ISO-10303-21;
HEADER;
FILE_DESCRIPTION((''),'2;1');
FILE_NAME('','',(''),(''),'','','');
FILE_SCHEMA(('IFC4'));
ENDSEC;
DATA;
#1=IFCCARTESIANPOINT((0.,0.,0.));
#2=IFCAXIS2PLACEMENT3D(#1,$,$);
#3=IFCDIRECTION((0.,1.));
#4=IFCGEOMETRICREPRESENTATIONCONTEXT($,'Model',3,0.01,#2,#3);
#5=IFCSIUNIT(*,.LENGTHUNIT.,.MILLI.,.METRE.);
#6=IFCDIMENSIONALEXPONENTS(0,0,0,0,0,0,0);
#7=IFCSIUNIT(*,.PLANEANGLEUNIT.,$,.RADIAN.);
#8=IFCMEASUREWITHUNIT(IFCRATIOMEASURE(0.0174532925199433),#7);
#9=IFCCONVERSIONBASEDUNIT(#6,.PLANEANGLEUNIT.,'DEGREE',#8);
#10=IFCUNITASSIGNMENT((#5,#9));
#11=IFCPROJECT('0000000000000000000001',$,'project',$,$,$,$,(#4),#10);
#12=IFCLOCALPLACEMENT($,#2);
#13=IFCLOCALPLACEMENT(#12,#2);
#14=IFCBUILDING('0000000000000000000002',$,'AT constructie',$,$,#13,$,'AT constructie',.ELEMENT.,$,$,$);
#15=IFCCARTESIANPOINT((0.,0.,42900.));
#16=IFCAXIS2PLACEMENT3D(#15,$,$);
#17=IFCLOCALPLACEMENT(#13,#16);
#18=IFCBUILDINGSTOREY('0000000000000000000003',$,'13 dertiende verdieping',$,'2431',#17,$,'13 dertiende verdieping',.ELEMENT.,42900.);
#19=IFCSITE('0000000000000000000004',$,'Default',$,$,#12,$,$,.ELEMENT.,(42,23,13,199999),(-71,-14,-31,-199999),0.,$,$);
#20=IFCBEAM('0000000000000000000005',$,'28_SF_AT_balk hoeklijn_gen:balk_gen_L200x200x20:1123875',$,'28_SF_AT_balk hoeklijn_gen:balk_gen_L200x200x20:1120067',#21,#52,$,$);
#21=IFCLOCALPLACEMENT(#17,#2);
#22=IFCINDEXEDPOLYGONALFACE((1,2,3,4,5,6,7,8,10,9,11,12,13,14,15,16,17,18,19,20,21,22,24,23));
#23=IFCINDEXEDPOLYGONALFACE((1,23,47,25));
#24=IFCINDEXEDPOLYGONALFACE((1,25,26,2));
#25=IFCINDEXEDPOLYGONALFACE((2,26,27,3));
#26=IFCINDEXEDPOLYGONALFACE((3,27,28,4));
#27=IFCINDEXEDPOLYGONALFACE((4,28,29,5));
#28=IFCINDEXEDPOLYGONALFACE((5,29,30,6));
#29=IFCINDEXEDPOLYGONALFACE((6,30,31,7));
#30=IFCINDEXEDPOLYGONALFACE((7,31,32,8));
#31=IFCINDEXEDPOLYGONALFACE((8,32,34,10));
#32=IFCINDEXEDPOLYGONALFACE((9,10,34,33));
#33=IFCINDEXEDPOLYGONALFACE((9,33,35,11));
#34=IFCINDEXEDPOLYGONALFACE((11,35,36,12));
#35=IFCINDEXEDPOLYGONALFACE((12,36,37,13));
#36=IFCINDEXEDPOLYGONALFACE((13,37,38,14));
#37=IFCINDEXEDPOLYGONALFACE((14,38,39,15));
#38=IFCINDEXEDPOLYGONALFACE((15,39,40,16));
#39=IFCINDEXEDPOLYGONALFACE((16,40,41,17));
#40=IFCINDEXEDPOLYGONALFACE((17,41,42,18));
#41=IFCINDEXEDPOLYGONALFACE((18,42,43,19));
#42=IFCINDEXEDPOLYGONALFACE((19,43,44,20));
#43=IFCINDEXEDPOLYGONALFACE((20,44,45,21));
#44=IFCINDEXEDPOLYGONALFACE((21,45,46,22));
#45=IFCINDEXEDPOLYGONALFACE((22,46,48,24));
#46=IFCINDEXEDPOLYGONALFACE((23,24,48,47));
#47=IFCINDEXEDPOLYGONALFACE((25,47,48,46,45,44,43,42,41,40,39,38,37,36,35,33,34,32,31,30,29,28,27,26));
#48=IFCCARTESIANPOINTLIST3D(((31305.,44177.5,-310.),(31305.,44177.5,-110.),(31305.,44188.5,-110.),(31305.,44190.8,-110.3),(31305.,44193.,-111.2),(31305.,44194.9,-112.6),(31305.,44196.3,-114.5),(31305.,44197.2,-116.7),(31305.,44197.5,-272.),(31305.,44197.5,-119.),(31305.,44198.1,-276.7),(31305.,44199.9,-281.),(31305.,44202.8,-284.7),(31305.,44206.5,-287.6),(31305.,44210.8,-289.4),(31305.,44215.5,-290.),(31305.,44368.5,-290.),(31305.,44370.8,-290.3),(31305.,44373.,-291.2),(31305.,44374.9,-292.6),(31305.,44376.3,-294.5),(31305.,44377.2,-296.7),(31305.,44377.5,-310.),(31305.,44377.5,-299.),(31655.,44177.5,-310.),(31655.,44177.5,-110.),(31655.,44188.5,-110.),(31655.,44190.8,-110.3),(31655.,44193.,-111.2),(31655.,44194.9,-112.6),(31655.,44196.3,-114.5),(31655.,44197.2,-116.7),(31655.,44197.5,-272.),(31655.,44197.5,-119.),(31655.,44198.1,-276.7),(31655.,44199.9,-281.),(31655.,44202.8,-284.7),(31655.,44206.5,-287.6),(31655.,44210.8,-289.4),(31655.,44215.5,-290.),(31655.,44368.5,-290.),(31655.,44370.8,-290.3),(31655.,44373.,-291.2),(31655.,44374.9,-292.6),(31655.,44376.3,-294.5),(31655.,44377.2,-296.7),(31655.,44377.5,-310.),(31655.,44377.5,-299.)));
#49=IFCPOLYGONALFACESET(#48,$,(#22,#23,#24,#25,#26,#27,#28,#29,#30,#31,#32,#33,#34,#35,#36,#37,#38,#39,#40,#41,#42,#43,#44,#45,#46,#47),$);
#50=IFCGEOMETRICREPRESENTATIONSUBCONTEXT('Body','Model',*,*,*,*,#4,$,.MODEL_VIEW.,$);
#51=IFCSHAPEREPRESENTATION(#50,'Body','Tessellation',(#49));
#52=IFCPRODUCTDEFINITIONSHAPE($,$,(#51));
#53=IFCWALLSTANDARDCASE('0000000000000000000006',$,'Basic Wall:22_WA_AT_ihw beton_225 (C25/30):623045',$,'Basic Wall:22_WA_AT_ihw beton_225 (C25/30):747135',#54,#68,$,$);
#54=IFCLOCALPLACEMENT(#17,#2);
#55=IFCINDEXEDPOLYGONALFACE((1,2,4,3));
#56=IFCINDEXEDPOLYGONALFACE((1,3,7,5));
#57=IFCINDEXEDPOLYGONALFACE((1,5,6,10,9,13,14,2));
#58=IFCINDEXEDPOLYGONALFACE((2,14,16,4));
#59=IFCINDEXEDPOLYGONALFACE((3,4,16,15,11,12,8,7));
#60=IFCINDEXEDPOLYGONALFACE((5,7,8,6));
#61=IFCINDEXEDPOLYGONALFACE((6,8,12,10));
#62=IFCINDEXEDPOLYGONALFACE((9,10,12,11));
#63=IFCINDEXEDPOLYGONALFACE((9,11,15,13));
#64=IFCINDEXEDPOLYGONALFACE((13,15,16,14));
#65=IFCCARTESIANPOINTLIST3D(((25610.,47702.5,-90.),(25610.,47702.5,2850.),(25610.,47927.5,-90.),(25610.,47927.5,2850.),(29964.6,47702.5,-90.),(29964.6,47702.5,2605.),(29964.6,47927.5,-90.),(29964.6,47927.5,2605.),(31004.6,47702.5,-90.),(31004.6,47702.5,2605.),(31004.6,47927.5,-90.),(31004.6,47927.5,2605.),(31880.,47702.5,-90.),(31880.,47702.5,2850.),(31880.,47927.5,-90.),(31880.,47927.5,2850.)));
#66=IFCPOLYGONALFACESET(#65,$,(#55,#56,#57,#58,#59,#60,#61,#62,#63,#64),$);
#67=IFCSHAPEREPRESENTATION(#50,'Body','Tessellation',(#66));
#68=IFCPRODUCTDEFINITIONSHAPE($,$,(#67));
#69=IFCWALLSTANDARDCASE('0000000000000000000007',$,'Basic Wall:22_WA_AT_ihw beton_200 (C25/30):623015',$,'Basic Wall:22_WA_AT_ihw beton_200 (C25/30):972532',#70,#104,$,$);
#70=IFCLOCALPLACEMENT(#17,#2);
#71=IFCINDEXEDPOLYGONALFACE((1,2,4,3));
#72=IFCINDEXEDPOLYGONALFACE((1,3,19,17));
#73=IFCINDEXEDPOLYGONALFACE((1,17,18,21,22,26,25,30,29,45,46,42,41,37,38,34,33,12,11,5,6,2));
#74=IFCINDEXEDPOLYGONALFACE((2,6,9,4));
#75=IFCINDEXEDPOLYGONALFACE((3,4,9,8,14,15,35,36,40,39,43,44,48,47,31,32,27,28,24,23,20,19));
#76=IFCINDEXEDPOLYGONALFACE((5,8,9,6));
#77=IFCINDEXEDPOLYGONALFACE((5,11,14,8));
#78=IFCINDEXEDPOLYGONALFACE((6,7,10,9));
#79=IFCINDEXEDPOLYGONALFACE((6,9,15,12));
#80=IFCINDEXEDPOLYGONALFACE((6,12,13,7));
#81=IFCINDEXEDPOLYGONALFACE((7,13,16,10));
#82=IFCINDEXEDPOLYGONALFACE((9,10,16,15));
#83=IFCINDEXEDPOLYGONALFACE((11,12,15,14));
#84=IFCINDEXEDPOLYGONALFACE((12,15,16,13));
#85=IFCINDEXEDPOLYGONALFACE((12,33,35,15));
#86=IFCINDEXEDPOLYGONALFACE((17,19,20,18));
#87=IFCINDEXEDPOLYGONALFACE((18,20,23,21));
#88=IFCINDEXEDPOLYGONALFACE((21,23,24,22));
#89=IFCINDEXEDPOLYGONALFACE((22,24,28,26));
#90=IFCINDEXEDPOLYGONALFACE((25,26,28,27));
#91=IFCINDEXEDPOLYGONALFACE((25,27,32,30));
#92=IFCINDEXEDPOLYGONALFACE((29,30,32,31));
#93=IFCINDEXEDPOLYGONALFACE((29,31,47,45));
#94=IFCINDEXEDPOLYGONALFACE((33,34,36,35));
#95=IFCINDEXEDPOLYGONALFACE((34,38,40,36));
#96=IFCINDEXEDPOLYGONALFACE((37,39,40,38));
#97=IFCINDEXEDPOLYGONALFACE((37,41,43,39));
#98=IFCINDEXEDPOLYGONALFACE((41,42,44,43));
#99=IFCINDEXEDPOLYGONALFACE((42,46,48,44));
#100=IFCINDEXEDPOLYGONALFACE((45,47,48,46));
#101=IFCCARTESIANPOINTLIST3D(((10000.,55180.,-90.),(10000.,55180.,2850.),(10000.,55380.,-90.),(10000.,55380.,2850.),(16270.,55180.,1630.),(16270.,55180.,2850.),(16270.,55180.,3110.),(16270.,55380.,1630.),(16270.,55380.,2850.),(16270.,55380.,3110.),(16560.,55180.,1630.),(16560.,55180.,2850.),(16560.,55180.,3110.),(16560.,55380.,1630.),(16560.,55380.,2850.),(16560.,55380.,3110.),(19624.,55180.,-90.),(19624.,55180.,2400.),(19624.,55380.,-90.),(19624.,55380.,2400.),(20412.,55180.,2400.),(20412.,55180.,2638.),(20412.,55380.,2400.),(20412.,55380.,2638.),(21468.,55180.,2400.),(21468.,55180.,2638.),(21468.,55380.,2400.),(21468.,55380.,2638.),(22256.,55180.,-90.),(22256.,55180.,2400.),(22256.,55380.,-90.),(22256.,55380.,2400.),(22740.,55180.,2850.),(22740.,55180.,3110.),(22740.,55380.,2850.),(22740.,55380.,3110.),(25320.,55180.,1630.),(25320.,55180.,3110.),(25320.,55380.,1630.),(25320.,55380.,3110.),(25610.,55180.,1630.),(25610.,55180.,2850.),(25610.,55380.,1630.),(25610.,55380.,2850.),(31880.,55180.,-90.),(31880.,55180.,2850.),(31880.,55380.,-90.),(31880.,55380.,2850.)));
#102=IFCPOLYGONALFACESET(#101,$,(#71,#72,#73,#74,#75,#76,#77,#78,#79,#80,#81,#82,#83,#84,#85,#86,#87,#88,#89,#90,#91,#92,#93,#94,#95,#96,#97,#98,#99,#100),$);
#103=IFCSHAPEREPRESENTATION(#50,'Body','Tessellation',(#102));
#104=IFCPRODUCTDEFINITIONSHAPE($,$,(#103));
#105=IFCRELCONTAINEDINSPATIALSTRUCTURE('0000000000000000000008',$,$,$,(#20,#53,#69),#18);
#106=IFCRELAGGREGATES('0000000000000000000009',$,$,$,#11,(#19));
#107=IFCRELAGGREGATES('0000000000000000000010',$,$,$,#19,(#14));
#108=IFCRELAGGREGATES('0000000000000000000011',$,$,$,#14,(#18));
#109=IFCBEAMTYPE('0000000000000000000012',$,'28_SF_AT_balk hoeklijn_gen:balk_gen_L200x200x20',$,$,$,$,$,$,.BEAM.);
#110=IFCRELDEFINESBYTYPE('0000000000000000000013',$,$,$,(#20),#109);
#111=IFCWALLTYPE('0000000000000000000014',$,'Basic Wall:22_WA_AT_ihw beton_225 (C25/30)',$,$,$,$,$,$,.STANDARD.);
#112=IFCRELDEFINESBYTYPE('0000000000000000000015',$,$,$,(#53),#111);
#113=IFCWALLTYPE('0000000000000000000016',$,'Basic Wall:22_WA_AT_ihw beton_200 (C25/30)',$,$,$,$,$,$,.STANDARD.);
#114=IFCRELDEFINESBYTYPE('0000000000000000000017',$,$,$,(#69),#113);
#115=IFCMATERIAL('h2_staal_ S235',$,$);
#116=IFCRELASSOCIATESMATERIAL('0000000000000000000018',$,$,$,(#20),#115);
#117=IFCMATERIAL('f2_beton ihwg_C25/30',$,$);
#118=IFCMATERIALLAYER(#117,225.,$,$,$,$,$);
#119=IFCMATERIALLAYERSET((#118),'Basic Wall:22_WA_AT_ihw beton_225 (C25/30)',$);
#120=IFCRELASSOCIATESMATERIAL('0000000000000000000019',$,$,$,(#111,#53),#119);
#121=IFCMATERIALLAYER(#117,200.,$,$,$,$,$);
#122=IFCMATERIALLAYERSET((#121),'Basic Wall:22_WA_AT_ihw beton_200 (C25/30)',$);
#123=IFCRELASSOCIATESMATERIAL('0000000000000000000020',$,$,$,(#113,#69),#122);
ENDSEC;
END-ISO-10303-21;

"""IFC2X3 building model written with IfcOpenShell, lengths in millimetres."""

from ifc_helpers import new_model, entity, si_unit, converted_unit, direction, frame, frame_2d, origin, place, context, subcontext, project, spatial, polyline, circle_curve, parameter, trimmed, segment, composite_curve, rectangle, outline, extrude, clip, bounded_halfspace, material, layer, layer_set, layer_usage, type_object, element, save


model = new_model("IFC2X3")

# Units and contexts
model_context = context("Model", 3, precision=0.01, world=origin(), true_north=direction((0.0, 1.0)))
body_context = subcontext(model_context, "Body", "Model", "MODEL_VIEW")
ifc_project = project(units=[si_unit("LENGTHUNIT", "METRE", prefix="MILLI"), converted_unit("PLANEANGLEUNIT", "DEGREE", entity("IfcRatioMeasure", 0.0174532925199433), si_unit("PLANEANGLEUNIT", "RADIAN"), dimensions=[0, 0, 0, 0, 0, 0, 0])], contexts=[model_context])

# Site, building, storey
site_placement = place(None, origin())
site = spatial("IfcSite", under=ifc_project, at=site_placement, Name="Default", CompositionType="ELEMENT", RefLatitude=(42, 23, 13, 199999), RefLongitude=(-71, -14, -31, -199999), RefElevation=0.0)
building_placement = place(site_placement, origin())
building = spatial("IfcBuilding", under=site, at=building_placement, Name="AT constructie", LongName="AT constructie", CompositionType="ELEMENT")
storey_placement = place(building_placement, frame((0.0, 0.0, 42900.0)))
storey = spatial("IfcBuildingStorey", under=building, at=storey_placement, Name="13 dertiende verdieping", ObjectType="2431", LongName="13 dertiende verdieping", CompositionType="ELEMENT", Elevation=42900.0)

# Beam
ifc_material_1 = material(Name="h2_staal_ S235")
beam_type = type_object("IfcBeamType", Name="28_SF_AT_balk hoeklijn_gen:balk_gen_L200x200x20", PredefinedType="BEAM")
beam_placement = place(storey_placement, frame((31305.0, 44177.5, -70.0)))
element("IfcBeam", 1, at=beam_placement, inside=storey, type_object=beam_type, material=ifc_material_1, Name="28_SF_AT_balk hoeklijn_gen:balk_gen_L200x200x20:1123875", ObjectType="28_SF_AT_balk hoeklijn_gen:balk_gen_L200x200x20:1120067", context=body_context, shape_type="SweptSolid", body=[
    extrude(outline(composite_curve([segment(polyline([(-124.4, -75.6), (75.6, -75.6)]), True, "CONTINUOUS"), segment(polyline([(75.6, -75.6), (75.6, 124.4)]), True, "CONTINUOUS"), segment(polyline([(75.6, 124.4), (64.6, 124.4)]), True, "CONTINUOUS"), segment(trimmed(circle_curve(frame_2d((64.6, 115.4), x_axis=(0.0, 1.0)), 9.0), [parameter(0.0)], [parameter(90.0)], True, "PARAMETER"), True, "CONTINUOUS"), segment(polyline([(55.6, 115.4), (55.6, -37.6)]), True, "CONTINUOUS"), segment(trimmed(circle_curve(frame_2d((37.6, -37.6), x_axis=(1.0, 0.0)), 18.0), [parameter(270.0)], [parameter(0.0)], True, "PARAMETER"), False, "CONTINUOUS"), segment(polyline([(37.6, -55.6), (-115.4, -55.6)]), True, "CONTINUOUS"), segment(trimmed(circle_curve(frame_2d((-115.4, -64.6), x_axis=(0.0, 1.0)), 9.0), [parameter(0.0)], [parameter(90.0)], True, "PARAMETER"), True, "CONTINUOUS"), segment(polyline([(-124.4, -64.6), (-124.4, -75.6)]), True, "CONTINUOUS")], self_intersect=False)), frame((0.0, 75.6, -164.4), z_axis=(1.0, 0.0, 0.0), x_axis=(0.0, 0.0, -1.0)), (0.0, 0.0, 1.0), 350.0),
])

# Wall, opening
ifc_material_2 = material(Name="f2_beton ihwg_C25/30")
ifc_layer_1 = layer(ifc_material_2, 225.0)
ifc_layer_set_1 = layer_set([ifc_layer_1], Name="Basic Wall:22_WA_AT_ihw beton_225 (C25/30)")
ifc_layer_usage_1 = layer_usage(ifc_layer_set_1, "AXIS2", "NEGATIVE", 112.5)
wall_type_1 = type_object("IfcWallType", Name="Basic Wall:22_WA_AT_ihw beton_225 (C25/30)", PredefinedType="STANDARD", material=ifc_layer_set_1)
wall_1_placement = place(storey_placement, frame((25610.0, 47815.0, -90.0)))
wall_1 = element("IfcWallStandardCase", 2, at=wall_1_placement, inside=storey, type_object=wall_type_1, material=ifc_layer_usage_1, Name="Basic Wall:22_WA_AT_ihw beton_225 (C25/30):623045", ObjectType="Basic Wall:22_WA_AT_ihw beton_225 (C25/30):747135", context=body_context, shape_type="SweptSolid", body=[
    extrude(rectangle(XDim=6270.0, YDim=225.0, at=frame_2d((3135.0, 0.0), x_axis=(-1.0, 0.0))), origin(), (0.0, 0.0, 1.0), 2940.0),
])
opening_1_placement = place(wall_1_placement, origin())
element("IfcOpeningElement", 3, at=opening_1_placement, cuts=wall_1, ObjectType="Opening", context=body_context, shape_type="SweptSolid", body=[
    extrude(rectangle(XDim=2695.0, YDim=1040.0, at=frame_2d((0.0, 0.0), x_axis=(1.0, 0.0))), frame((4874.6, -1411.5, 1347.5), z_axis=(0.0, 1.0, 0.0), x_axis=(0.0, 0.0, -1.0)), (0.0, 0.0, 1.0), 3048.0),
])

# Wall, openings
ifc_layer_2 = layer(ifc_material_2, 200.0)
ifc_layer_set_2 = layer_set([ifc_layer_2], Name="Basic Wall:22_WA_AT_ihw beton_200 (C25/30)")
ifc_layer_usage_2 = layer_usage(ifc_layer_set_2, "AXIS2", "NEGATIVE", 100.0)
wall_type_2 = type_object("IfcWallType", Name="Basic Wall:22_WA_AT_ihw beton_200 (C25/30)", PredefinedType="STANDARD", material=ifc_layer_set_2)
wall_2_placement = place(storey_placement, frame((10000.0, 55280.0, -90.0)))
wall_2 = element("IfcWallStandardCase", 4, at=wall_2_placement, inside=storey, type_object=wall_type_2, material=ifc_layer_usage_2, Name="Basic Wall:22_WA_AT_ihw beton_200 (C25/30):623015", ObjectType="Basic Wall:22_WA_AT_ihw beton_200 (C25/30):972532", context=body_context, shape_type="Clipping", body=[
    clip(clip(clip(clip(clip(clip(clip(extrude(rectangle(XDim=21880.0, YDim=200.0, at=frame_2d((10940.0, 0.0), x_axis=(-1.0, 0.0))), origin(), (0.0, 0.0, 1.0), 3200.0), bounded_halfspace(frame((12740.0, -100.0, 2940.0), z_axis=(0.0, 0.0, -1.0), x_axis=(0.0, 1.0, 0.0)), True, frame((12740.0, -100.0, 2940.0)), polyline([(0.0, 0.0), (0.0, 200.0), (-6180.0, 200.0), (-6180.0, 0.0), (-3600.0, 0.0), (-3350.0, 0.0), (-250.0, 0.0), (0.0, 0.0)]))), bounded_halfspace(frame((21880.0, -100.0, 2940.0), z_axis=(0.0, 0.0, -1.0), x_axis=(0.0, -1.0, 0.0)), True, frame((21880.0, -100.0, 2940.0)), polyline([(0.0, 0.0), (0.0, 200.0), (-6270.0, 200.0), (-6270.0, 0.0), (0.0, 0.0)]))), bounded_halfspace(frame((12740.0, 100.0, 3200.0), z_axis=(0.0, 0.0, -1.0), x_axis=(0.0, 1.0, 0.0)), True, frame((12740.0, 100.0, 3200.0)), polyline([(0.0, 0.0), (0.0, -200.0), (2580.0, -200.0), (2580.0, 0.0), (0.0, 0.0)]))), bounded_halfspace(frame((0.0, 100.0, 2940.0), z_axis=(0.0, 0.0, -1.0), x_axis=(0.0, -1.0, 0.0)), True, frame((0.0, 100.0, 2940.0)), polyline([(0.0, 0.0), (0.0, -200.0), (6270.0, -200.0), (6270.0, 0.0), (0.0, 0.0)]))), bounded_halfspace(frame((12740.0, -100.0, 2940.0), z_axis=(0.0, 0.0, -1.0), x_axis=(0.0, 1.0, 0.0)), True, frame((12740.0, -100.0, 2940.0)), polyline([(0.0, 0.0), (0.0, 200.0), (-6180.0, 200.0), (-6180.0, 0.0), (-3600.0, 0.0), (-3350.0, 0.0), (-250.0, 0.0), (0.0, 0.0)]))), bounded_halfspace(frame((21880.0, -100.0, 2940.0), z_axis=(0.0, 0.0, -1.0), x_axis=(0.0, -1.0, 0.0)), True, frame((21880.0, -100.0, 2940.0)), polyline([(0.0, 0.0), (0.0, 200.0), (-6270.0, 200.0), (-6270.0, 0.0), (0.0, 0.0)]))), bounded_halfspace(frame((0.0, 100.0, 2940.0), z_axis=(0.0, 0.0, -1.0), x_axis=(0.0, -1.0, 0.0)), True, frame((0.0, 100.0, 2940.0)), polyline([(0.0, 0.0), (0.0, -200.0), (6270.0, -200.0), (6270.0, 0.0), (0.0, 0.0)]))),
])
opening_2_placement = place(wall_2_placement, origin())
element("IfcOpeningElement", 5, at=opening_2_placement, cuts=wall_2, ObjectType="Opening", context=body_context, shape_type="SweptSolid", body=[
    extrude(rectangle(XDim=2490.0, YDim=2632.0, at=frame_2d((0.0, 0.0), x_axis=(1.0, 0.0))), frame((10940.0, -1424.0, 1245.0), z_axis=(0.0, 1.0, 0.0), x_axis=(0.0, 0.0, -1.0)), (0.0, 0.0, 1.0), 3048.0),
])
opening_3_placement = place(wall_2_placement, origin())
element("IfcOpeningElement", 6, at=opening_3_placement, cuts=wall_2, ObjectType="Opening", context=body_context, shape_type="SweptSolid", body=[
    extrude(rectangle(XDim=1480.0, YDim=290.0, at=frame_2d((0.0, 0.0), x_axis=(0.0, 1.0))), frame((15465.0, -100.0, 2460.0), z_axis=(0.0, 1.0, 0.0), x_axis=(-1.0, 0.0, 0.0)), (0.0, 0.0, 1.0), 200.0),
])
opening_4_placement = place(wall_2_placement, origin())
element("IfcOpeningElement", 7, at=opening_4_placement, cuts=wall_2, ObjectType="Opening", context=body_context, shape_type="SweptSolid", body=[
    extrude(rectangle(XDim=1220.0, YDim=290.0, at=frame_2d((0.0, 0.0), x_axis=(0.0, 1.0))), frame((6415.0, -100.0, 2330.0), z_axis=(0.0, 1.0, 0.0), x_axis=(-1.0, 0.0, 0.0)), (0.0, 0.0, 1.0), 200.0),
])
opening_5_placement = place(wall_2_placement, origin())
element("IfcOpeningElement", 8, at=opening_5_placement, cuts=wall_2, ObjectType="Opening", context=body_context, shape_type="SweptSolid", body=[
    extrude(rectangle(XDim=238.0, YDim=1056.0, at=frame_2d((0.0, 0.0), x_axis=(1.0, 0.0))), frame((10940.0, -1424.0, 2609.0), z_axis=(0.0, 1.0, 0.0), x_axis=(0.0, 0.0, -1.0)), (0.0, 0.0, 1.0), 3048.0),
])
opening_6_placement = place(wall_2_placement, origin())
element("IfcOpeningElement", 9, at=opening_6_placement, cuts=wall_2, ObjectType="Opening", context=body_context, shape_type="SweptSolid", body=[
    extrude(rectangle(XDim=2490.0, YDim=250.0, at=frame_2d((0.0, 0.0), x_axis=(0.0, 1.0))), frame((9265.0, -1270.0, 1245.0), z_axis=(0.0, 1.0, 0.0), x_axis=(1.0, 0.0, 0.0)), (0.0, 0.0, 1.0), 1170.0),
])

save(model, "model.ifc")
